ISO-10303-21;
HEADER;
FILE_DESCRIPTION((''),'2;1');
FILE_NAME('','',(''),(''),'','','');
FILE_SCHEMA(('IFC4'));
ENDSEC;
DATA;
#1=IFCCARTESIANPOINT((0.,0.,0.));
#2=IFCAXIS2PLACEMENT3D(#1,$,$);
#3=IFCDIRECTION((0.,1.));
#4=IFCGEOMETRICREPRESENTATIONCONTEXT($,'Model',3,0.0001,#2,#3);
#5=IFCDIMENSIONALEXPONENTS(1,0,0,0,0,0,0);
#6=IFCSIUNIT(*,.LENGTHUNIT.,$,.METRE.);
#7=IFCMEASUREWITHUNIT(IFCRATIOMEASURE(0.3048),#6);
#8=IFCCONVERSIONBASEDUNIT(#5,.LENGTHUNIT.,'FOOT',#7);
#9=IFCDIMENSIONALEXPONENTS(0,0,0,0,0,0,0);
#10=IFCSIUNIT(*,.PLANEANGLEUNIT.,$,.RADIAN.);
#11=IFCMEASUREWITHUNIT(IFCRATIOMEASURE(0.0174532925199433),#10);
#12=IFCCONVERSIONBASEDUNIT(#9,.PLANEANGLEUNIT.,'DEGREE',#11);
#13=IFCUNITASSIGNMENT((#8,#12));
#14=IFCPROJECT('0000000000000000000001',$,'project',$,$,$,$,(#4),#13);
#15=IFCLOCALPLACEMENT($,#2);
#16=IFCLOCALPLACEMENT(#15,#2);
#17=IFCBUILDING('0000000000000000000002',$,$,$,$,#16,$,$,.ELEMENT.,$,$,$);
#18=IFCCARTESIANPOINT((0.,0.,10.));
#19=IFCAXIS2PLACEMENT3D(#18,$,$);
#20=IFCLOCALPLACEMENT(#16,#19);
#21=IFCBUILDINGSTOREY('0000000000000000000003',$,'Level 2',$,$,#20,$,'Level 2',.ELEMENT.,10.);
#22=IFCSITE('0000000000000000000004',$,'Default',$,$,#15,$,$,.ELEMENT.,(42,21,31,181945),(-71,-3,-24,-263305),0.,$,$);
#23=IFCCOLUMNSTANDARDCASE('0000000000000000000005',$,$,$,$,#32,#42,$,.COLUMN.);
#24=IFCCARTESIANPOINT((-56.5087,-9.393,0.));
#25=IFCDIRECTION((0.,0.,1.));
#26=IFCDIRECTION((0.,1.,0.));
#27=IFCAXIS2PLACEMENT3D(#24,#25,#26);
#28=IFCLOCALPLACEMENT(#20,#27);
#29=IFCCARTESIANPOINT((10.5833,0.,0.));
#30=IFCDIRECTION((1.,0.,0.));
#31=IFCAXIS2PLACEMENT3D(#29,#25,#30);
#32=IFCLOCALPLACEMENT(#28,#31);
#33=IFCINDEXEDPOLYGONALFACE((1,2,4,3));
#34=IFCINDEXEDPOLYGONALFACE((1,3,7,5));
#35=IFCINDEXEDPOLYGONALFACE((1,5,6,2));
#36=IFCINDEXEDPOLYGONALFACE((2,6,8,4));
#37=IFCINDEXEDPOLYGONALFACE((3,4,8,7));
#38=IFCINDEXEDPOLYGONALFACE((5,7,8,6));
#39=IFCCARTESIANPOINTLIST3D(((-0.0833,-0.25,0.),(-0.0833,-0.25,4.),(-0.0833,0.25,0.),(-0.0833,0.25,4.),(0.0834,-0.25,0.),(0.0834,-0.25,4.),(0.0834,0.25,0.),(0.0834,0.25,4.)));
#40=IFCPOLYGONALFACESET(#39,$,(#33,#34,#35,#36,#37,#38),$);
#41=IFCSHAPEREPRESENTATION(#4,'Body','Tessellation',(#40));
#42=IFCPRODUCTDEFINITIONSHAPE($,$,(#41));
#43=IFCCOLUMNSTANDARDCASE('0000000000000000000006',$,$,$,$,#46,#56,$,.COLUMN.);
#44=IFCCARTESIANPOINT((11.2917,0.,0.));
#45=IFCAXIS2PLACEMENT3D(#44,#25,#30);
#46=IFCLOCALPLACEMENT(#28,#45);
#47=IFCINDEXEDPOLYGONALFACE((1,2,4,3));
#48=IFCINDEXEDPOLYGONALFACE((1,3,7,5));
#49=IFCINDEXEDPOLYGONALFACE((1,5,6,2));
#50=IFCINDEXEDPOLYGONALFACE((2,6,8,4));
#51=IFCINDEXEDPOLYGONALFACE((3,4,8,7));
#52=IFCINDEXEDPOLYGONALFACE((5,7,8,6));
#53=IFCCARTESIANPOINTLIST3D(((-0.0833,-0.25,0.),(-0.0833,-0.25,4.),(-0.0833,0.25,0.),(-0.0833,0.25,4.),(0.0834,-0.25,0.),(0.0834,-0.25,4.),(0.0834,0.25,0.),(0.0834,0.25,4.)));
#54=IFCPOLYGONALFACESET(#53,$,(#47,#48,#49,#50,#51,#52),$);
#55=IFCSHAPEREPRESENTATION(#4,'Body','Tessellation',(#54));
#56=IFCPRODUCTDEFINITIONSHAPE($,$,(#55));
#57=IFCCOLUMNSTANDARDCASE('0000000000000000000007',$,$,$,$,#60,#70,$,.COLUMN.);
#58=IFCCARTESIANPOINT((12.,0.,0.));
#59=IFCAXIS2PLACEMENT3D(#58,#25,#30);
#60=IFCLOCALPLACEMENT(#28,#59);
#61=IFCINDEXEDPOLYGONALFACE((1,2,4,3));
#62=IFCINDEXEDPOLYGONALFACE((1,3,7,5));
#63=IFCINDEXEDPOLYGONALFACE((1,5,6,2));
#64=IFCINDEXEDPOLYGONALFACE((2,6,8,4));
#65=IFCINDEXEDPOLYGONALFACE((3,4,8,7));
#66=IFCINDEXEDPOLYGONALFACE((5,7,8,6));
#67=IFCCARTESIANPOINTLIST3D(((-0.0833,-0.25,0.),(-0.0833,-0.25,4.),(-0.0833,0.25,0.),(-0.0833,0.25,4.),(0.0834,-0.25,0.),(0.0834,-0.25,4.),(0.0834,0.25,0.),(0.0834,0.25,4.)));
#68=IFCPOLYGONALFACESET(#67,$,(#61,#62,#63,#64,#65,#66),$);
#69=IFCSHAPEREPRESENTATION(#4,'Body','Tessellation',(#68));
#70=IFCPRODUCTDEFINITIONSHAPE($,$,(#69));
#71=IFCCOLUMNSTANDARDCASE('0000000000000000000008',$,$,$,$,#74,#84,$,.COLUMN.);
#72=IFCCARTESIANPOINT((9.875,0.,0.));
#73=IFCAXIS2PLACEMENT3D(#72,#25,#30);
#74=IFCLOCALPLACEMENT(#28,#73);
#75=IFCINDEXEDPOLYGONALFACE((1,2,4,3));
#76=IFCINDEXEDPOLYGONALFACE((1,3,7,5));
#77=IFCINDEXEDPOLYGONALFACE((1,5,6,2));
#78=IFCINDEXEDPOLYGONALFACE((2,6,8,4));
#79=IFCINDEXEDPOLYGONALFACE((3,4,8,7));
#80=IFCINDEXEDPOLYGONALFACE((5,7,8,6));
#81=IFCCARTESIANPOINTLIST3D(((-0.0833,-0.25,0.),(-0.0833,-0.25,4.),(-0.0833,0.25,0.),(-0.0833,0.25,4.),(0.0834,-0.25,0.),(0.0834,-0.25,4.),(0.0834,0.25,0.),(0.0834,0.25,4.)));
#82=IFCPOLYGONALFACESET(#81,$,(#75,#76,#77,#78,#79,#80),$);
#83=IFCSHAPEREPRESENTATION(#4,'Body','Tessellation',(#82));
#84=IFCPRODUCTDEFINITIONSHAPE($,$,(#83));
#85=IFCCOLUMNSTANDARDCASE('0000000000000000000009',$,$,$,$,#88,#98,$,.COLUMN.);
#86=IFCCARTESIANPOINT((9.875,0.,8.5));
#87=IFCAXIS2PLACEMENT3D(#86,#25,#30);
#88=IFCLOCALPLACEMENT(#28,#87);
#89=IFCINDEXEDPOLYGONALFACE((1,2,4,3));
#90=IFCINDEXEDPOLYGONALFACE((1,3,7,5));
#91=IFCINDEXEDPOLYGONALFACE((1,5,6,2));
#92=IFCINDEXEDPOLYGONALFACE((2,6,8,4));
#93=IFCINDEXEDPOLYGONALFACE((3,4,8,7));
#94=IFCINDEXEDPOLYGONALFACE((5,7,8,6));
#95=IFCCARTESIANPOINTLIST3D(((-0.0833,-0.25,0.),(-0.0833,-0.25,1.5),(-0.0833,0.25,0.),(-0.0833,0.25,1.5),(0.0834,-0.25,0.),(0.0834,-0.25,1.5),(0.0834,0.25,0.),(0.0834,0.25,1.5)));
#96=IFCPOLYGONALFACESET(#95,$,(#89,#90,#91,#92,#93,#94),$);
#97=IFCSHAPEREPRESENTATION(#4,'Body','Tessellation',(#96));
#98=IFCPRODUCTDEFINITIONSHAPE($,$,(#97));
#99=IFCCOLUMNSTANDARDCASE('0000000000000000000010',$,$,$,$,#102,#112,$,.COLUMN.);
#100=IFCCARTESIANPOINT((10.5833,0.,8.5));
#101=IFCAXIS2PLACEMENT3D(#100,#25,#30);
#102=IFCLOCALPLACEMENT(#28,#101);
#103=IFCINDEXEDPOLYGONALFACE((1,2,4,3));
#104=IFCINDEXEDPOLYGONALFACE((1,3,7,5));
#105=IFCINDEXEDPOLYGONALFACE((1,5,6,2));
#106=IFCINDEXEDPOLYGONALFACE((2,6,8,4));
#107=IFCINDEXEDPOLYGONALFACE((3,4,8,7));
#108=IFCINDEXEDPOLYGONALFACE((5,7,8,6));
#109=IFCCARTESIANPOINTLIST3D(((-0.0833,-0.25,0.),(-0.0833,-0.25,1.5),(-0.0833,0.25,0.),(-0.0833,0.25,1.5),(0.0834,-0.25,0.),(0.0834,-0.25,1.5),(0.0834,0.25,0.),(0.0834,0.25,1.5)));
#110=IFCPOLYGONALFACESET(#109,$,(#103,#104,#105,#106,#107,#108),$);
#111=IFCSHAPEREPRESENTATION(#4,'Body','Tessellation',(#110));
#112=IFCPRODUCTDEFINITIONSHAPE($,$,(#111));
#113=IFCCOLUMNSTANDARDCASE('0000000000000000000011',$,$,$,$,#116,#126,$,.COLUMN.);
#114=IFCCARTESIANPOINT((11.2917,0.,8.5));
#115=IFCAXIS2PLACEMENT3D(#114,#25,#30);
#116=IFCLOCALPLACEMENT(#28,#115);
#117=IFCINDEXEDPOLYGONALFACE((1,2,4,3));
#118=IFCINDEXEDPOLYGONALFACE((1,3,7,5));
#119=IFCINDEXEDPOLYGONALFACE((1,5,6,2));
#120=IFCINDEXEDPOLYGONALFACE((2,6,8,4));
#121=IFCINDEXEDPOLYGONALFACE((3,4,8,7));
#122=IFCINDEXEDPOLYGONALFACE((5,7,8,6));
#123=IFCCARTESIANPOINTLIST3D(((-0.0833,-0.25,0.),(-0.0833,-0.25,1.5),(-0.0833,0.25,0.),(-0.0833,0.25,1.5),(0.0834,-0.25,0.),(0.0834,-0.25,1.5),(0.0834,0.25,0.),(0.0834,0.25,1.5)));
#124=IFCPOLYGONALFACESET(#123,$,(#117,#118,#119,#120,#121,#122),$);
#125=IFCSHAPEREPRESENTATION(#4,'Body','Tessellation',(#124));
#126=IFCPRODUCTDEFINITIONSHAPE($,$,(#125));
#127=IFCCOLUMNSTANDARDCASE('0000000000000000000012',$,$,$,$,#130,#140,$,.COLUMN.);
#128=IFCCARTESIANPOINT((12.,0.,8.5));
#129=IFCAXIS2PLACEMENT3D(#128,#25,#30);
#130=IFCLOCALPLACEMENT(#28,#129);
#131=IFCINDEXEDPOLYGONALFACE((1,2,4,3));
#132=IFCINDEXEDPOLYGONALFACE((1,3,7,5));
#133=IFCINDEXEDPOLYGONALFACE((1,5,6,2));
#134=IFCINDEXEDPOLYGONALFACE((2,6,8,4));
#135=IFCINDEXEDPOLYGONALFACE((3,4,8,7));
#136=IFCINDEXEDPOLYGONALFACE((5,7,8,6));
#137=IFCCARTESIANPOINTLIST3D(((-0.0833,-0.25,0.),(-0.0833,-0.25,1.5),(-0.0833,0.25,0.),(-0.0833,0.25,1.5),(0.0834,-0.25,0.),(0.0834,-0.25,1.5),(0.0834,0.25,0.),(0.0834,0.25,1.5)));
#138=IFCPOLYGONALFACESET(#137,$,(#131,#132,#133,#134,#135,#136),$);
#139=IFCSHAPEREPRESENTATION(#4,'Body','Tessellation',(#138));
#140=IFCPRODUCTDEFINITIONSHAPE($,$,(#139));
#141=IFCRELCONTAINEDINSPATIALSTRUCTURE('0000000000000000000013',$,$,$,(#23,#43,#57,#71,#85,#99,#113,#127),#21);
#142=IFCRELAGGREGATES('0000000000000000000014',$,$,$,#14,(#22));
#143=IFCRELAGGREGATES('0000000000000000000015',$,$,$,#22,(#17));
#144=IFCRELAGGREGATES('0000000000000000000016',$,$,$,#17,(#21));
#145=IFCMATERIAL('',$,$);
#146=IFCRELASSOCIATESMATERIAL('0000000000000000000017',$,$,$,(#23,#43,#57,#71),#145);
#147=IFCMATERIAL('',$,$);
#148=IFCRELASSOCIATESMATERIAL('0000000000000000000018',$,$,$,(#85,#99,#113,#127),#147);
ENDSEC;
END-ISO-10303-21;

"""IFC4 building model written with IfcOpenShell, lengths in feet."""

from ifc_helpers import new_model, entity, si_unit, converted_unit, direction, frame, origin, place, context, project, spatial, rectangle, extrude, material, element, save


model = new_model("IFC4")

# Units and contexts
model_context = context("Model", 3, precision=0.0001, world=origin(), true_north=direction((0.0, 1.0)))
ifc_project = project(units=[converted_unit("LENGTHUNIT", "FOOT", entity("IfcRatioMeasure", 0.3048), si_unit("LENGTHUNIT", "METRE"), dimensions=[1, 0, 0, 0, 0, 0, 0]), converted_unit("PLANEANGLEUNIT", "DEGREE", entity("IfcRatioMeasure", 0.0174532925199433), si_unit("PLANEANGLEUNIT", "RADIAN"), dimensions=[0, 0, 0, 0, 0, 0, 0])], contexts=[model_context])

# Site, building, storey
site_placement = place(None, origin())
site = spatial("IfcSite", under=ifc_project, at=site_placement, Name="Default", CompositionType="ELEMENT", RefLatitude=(42, 21, 31, 181945), RefLongitude=(-71, -3, -24, -263305), RefElevation=0.0)
building_placement = place(site_placement, origin())
building = spatial("IfcBuilding", under=site, at=building_placement, CompositionType="ELEMENT")
storey_placement = place(building_placement, frame((0.0, 0.0, 10.0)))
storey = spatial("IfcBuildingStorey", under=building, at=storey_placement, Name="Level 2", LongName="Level 2", CompositionType="ELEMENT", Elevation=10.0)

# Columns
ifc_material_1 = material(Name="")
placement = place(storey_placement, frame((-56.5087, -9.393, 0.0), z_axis=(0.0, 0.0, 1.0), x_axis=(0.0, 1.0, 0.0)))
for number, where, z_axis, x_axis in (
    (1, (10.5833, 0.0, 0.0), (0.0, 0.0, 1.0), (1.0, 0.0, 0.0)),
    (2, (11.2917, 0.0, 0.0), (0.0, 0.0, 1.0), (1.0, 0.0, 0.0)),
    (3, (12.0, 0.0, 0.0), (0.0, 0.0, 1.0), (1.0, 0.0, 0.0)),
    (4, (9.875, 0.0, 0.0), (0.0, 0.0, 1.0), (1.0, 0.0, 0.0)),
):
    element("IfcColumnStandardCase", number, at=place(placement, frame(where, z_axis=z_axis, x_axis=x_axis)), inside=storey, material=ifc_material_1, PredefinedType="COLUMN", context=model_context, shape_type="SweptSolid", body=[
        extrude(rectangle(XDim=0.1667, YDim=0.5), origin(), (0.0, 0.0, 1.0), 4.0),
    ])
ifc_material_2 = material(Name="")
for number, where, z_axis, x_axis in (
    (5, (9.875, 0.0, 8.5), (0.0, 0.0, 1.0), (1.0, 0.0, 0.0)),
    (6, (10.5833, 0.0, 8.5), (0.0, 0.0, 1.0), (1.0, 0.0, 0.0)),
    (7, (11.2917, 0.0, 8.5), (0.0, 0.0, 1.0), (1.0, 0.0, 0.0)),
    (8, (12.0, 0.0, 8.5), (0.0, 0.0, 1.0), (1.0, 0.0, 0.0)),
):
    element("IfcColumnStandardCase", number, at=place(placement, frame(where, z_axis=z_axis, x_axis=x_axis)), inside=storey, material=ifc_material_2, PredefinedType="COLUMN", context=model_context, shape_type="SweptSolid", body=[
        extrude(rectangle(XDim=0.1667, YDim=0.5), origin(), (0.0, 0.0, 1.0), 1.5),
    ])

save(model, "model.ifc")
